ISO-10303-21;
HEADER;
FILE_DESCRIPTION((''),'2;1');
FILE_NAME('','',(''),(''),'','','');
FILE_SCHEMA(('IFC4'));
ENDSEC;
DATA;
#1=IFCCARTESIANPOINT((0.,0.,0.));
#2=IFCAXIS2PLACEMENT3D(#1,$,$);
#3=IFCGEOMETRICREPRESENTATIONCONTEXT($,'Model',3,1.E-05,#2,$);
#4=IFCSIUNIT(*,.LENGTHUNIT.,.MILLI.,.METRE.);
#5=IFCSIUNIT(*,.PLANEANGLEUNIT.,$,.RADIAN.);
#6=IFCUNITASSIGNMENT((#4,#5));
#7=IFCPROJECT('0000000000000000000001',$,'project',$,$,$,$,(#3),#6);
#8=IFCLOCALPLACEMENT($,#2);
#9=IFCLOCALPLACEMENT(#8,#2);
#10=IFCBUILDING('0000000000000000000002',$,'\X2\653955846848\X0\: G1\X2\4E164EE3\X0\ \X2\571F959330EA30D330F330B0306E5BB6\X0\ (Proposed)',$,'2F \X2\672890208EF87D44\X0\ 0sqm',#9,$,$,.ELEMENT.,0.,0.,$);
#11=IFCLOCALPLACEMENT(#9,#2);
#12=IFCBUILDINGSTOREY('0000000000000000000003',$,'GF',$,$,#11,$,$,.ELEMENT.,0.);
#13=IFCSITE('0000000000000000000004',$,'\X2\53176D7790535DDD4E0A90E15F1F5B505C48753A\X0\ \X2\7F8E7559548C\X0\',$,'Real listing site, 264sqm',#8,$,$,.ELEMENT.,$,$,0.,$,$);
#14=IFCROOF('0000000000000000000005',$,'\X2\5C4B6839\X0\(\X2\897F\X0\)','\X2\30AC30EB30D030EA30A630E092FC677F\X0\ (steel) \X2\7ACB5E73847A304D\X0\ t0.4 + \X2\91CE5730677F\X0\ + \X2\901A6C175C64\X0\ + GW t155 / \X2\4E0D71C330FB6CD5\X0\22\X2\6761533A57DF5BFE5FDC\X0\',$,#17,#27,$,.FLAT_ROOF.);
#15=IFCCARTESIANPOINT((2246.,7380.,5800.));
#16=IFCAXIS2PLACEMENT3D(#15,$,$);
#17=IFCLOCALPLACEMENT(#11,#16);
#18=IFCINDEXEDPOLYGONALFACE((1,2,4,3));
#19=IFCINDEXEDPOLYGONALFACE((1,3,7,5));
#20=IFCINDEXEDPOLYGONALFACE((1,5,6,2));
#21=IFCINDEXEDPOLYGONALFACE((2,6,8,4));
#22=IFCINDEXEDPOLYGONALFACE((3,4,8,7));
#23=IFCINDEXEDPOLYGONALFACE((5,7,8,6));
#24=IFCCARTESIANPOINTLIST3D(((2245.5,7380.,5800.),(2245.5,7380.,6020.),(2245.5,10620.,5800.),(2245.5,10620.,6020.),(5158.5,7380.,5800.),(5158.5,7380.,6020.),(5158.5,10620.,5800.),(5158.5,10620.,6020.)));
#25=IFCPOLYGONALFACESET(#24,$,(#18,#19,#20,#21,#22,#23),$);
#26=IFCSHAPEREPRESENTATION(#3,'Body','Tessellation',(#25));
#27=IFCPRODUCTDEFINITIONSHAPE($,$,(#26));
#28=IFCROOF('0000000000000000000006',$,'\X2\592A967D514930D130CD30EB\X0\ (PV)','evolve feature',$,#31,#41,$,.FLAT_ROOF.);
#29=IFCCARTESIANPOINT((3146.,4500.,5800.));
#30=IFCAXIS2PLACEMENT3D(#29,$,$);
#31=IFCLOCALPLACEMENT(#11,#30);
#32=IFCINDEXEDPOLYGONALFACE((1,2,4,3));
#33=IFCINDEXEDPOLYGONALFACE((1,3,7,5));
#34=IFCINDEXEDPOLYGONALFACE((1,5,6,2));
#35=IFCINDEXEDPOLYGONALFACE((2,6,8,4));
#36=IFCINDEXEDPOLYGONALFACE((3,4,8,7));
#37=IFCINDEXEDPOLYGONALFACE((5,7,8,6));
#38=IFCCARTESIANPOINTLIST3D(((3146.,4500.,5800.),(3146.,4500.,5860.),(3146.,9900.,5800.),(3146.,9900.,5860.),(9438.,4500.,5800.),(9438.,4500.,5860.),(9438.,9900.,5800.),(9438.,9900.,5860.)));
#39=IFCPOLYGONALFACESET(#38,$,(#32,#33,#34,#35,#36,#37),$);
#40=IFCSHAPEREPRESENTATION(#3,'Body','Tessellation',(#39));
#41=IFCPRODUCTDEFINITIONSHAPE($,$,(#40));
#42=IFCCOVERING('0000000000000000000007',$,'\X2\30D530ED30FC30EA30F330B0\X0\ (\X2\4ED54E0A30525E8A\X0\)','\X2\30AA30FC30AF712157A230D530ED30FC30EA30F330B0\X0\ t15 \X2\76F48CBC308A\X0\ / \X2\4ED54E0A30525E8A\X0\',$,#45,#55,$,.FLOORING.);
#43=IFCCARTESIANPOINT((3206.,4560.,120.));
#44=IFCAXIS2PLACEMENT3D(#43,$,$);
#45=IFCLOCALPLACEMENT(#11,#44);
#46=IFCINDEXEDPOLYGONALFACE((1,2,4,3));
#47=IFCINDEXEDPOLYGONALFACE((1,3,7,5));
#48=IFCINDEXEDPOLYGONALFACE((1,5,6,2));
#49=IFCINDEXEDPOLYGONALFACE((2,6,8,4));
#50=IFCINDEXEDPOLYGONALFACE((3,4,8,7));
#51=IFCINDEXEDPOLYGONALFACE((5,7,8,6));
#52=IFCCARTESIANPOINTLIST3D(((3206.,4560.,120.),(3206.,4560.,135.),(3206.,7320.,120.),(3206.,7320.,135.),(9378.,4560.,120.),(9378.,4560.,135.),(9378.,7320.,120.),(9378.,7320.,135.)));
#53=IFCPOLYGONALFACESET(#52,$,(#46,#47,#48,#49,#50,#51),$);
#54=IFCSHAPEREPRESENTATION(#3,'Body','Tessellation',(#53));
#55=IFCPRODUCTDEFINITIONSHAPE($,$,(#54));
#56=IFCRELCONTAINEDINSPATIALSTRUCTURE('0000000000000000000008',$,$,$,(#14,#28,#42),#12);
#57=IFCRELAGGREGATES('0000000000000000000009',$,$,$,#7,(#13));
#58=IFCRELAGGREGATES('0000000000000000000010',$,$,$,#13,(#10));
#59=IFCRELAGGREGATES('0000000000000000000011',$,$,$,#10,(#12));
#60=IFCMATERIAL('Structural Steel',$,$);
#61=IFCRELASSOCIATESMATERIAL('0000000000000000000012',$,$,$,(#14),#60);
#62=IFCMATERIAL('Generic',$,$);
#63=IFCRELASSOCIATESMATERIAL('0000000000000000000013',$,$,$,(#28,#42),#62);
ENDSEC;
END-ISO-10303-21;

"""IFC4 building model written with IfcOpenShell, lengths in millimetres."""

from ifc_helpers import new_model, si_unit, frame, frame_2d, origin, place, context, project, spatial, rectangle, extrude, material, element, save


model = new_model("IFC4")

# Units and contexts
model_context = context("Model", 3, precision=1e-05, world=origin())
ifc_project = project(units=[si_unit("LENGTHUNIT", "METRE", prefix="MILLI"), si_unit("PLANEANGLEUNIT", "RADIAN")], contexts=[model_context])

# Site, building, storey
site_placement = place(None, origin())
site = spatial("IfcSite", under=ifc_project, at=site_placement, Name="北海道川上郡弟子屈町 美留和", ObjectType="Real listing site, 264sqm", CompositionType="ELEMENT", RefElevation=0.0)
building_placement = place(site_placement, origin())
building = spatial("IfcBuilding", under=site, at=building_placement, Name="改善案: G1世代 土間リビングの家 (Proposed)", ObjectType="2F 木造軸組 0sqm", CompositionType="ELEMENT", ElevationOfRefHeight=0.0, ElevationOfTerrain=0.0)
storey_placement = place(building_placement, origin())
storey = spatial("IfcBuildingStorey", under=building, at=storey_placement, Name="GF", CompositionType="ELEMENT", Elevation=0.0)

# Shared definitions
ifc_material_1 = material(Name="Generic")

# Roofs
ifc_material_2 = material(Name="Structural Steel")
roof_1_placement = place(storey_placement, frame((2246.0, 7380.0, 5800.0)))
element("IfcRoof", 1, at=roof_1_placement, inside=storey, material=ifc_material_2, Name="屋根(西)", Description="ガルバリウム鋼板 (steel) 立平葺き t0.4 + 野地板 + 通気層 + GW t155 / 不燃・法22条区域対応", PredefinedType="FLAT_ROOF", context=model_context, shape_type="SweptSolid", body=[
    extrude(rectangle(XDim=2913.0, YDim=3240.0, at=frame_2d((1456.0, 1620.0))), frame((2246.0, 7380.0, 5800.0)), (0.0, 0.0, 1.0), 220.0),
])
roof_2_placement = place(storey_placement, frame((3146.0, 4500.0, 5800.0)))
element("IfcRoof", 2, at=roof_2_placement, inside=storey, material=ifc_material_1, Name="太陽光パネル (PV)", Description="evolve feature", PredefinedType="FLAT_ROOF", context=model_context, shape_type="SweptSolid", body=[
    extrude(rectangle(XDim=6292.0, YDim=5400.0, at=frame_2d((3146.0, 2700.0))), frame((3146.0, 4500.0, 5800.0)), (0.0, 0.0, 1.0), 60.0),
])

# Covering
covering_placement = place(storey_placement, frame((3206.0, 4560.0, 120.0)))
element("IfcCovering", 3, at=covering_placement, inside=storey, material=ifc_material_1, Name="フローリング (仕上げ床)", Description="オーク無垢フローリング t15 直貼り / 仕上げ床", PredefinedType="FLOORING", context=model_context, shape_type="SweptSolid", body=[
    extrude(rectangle(XDim=6172.0, YDim=2760.0, at=frame_2d((3086.0, 1380.0))), frame((3206.0, 4560.0, 120.0)), (0.0, 0.0, 1.0), 15.0),
])

save(model, "model.ifc")
